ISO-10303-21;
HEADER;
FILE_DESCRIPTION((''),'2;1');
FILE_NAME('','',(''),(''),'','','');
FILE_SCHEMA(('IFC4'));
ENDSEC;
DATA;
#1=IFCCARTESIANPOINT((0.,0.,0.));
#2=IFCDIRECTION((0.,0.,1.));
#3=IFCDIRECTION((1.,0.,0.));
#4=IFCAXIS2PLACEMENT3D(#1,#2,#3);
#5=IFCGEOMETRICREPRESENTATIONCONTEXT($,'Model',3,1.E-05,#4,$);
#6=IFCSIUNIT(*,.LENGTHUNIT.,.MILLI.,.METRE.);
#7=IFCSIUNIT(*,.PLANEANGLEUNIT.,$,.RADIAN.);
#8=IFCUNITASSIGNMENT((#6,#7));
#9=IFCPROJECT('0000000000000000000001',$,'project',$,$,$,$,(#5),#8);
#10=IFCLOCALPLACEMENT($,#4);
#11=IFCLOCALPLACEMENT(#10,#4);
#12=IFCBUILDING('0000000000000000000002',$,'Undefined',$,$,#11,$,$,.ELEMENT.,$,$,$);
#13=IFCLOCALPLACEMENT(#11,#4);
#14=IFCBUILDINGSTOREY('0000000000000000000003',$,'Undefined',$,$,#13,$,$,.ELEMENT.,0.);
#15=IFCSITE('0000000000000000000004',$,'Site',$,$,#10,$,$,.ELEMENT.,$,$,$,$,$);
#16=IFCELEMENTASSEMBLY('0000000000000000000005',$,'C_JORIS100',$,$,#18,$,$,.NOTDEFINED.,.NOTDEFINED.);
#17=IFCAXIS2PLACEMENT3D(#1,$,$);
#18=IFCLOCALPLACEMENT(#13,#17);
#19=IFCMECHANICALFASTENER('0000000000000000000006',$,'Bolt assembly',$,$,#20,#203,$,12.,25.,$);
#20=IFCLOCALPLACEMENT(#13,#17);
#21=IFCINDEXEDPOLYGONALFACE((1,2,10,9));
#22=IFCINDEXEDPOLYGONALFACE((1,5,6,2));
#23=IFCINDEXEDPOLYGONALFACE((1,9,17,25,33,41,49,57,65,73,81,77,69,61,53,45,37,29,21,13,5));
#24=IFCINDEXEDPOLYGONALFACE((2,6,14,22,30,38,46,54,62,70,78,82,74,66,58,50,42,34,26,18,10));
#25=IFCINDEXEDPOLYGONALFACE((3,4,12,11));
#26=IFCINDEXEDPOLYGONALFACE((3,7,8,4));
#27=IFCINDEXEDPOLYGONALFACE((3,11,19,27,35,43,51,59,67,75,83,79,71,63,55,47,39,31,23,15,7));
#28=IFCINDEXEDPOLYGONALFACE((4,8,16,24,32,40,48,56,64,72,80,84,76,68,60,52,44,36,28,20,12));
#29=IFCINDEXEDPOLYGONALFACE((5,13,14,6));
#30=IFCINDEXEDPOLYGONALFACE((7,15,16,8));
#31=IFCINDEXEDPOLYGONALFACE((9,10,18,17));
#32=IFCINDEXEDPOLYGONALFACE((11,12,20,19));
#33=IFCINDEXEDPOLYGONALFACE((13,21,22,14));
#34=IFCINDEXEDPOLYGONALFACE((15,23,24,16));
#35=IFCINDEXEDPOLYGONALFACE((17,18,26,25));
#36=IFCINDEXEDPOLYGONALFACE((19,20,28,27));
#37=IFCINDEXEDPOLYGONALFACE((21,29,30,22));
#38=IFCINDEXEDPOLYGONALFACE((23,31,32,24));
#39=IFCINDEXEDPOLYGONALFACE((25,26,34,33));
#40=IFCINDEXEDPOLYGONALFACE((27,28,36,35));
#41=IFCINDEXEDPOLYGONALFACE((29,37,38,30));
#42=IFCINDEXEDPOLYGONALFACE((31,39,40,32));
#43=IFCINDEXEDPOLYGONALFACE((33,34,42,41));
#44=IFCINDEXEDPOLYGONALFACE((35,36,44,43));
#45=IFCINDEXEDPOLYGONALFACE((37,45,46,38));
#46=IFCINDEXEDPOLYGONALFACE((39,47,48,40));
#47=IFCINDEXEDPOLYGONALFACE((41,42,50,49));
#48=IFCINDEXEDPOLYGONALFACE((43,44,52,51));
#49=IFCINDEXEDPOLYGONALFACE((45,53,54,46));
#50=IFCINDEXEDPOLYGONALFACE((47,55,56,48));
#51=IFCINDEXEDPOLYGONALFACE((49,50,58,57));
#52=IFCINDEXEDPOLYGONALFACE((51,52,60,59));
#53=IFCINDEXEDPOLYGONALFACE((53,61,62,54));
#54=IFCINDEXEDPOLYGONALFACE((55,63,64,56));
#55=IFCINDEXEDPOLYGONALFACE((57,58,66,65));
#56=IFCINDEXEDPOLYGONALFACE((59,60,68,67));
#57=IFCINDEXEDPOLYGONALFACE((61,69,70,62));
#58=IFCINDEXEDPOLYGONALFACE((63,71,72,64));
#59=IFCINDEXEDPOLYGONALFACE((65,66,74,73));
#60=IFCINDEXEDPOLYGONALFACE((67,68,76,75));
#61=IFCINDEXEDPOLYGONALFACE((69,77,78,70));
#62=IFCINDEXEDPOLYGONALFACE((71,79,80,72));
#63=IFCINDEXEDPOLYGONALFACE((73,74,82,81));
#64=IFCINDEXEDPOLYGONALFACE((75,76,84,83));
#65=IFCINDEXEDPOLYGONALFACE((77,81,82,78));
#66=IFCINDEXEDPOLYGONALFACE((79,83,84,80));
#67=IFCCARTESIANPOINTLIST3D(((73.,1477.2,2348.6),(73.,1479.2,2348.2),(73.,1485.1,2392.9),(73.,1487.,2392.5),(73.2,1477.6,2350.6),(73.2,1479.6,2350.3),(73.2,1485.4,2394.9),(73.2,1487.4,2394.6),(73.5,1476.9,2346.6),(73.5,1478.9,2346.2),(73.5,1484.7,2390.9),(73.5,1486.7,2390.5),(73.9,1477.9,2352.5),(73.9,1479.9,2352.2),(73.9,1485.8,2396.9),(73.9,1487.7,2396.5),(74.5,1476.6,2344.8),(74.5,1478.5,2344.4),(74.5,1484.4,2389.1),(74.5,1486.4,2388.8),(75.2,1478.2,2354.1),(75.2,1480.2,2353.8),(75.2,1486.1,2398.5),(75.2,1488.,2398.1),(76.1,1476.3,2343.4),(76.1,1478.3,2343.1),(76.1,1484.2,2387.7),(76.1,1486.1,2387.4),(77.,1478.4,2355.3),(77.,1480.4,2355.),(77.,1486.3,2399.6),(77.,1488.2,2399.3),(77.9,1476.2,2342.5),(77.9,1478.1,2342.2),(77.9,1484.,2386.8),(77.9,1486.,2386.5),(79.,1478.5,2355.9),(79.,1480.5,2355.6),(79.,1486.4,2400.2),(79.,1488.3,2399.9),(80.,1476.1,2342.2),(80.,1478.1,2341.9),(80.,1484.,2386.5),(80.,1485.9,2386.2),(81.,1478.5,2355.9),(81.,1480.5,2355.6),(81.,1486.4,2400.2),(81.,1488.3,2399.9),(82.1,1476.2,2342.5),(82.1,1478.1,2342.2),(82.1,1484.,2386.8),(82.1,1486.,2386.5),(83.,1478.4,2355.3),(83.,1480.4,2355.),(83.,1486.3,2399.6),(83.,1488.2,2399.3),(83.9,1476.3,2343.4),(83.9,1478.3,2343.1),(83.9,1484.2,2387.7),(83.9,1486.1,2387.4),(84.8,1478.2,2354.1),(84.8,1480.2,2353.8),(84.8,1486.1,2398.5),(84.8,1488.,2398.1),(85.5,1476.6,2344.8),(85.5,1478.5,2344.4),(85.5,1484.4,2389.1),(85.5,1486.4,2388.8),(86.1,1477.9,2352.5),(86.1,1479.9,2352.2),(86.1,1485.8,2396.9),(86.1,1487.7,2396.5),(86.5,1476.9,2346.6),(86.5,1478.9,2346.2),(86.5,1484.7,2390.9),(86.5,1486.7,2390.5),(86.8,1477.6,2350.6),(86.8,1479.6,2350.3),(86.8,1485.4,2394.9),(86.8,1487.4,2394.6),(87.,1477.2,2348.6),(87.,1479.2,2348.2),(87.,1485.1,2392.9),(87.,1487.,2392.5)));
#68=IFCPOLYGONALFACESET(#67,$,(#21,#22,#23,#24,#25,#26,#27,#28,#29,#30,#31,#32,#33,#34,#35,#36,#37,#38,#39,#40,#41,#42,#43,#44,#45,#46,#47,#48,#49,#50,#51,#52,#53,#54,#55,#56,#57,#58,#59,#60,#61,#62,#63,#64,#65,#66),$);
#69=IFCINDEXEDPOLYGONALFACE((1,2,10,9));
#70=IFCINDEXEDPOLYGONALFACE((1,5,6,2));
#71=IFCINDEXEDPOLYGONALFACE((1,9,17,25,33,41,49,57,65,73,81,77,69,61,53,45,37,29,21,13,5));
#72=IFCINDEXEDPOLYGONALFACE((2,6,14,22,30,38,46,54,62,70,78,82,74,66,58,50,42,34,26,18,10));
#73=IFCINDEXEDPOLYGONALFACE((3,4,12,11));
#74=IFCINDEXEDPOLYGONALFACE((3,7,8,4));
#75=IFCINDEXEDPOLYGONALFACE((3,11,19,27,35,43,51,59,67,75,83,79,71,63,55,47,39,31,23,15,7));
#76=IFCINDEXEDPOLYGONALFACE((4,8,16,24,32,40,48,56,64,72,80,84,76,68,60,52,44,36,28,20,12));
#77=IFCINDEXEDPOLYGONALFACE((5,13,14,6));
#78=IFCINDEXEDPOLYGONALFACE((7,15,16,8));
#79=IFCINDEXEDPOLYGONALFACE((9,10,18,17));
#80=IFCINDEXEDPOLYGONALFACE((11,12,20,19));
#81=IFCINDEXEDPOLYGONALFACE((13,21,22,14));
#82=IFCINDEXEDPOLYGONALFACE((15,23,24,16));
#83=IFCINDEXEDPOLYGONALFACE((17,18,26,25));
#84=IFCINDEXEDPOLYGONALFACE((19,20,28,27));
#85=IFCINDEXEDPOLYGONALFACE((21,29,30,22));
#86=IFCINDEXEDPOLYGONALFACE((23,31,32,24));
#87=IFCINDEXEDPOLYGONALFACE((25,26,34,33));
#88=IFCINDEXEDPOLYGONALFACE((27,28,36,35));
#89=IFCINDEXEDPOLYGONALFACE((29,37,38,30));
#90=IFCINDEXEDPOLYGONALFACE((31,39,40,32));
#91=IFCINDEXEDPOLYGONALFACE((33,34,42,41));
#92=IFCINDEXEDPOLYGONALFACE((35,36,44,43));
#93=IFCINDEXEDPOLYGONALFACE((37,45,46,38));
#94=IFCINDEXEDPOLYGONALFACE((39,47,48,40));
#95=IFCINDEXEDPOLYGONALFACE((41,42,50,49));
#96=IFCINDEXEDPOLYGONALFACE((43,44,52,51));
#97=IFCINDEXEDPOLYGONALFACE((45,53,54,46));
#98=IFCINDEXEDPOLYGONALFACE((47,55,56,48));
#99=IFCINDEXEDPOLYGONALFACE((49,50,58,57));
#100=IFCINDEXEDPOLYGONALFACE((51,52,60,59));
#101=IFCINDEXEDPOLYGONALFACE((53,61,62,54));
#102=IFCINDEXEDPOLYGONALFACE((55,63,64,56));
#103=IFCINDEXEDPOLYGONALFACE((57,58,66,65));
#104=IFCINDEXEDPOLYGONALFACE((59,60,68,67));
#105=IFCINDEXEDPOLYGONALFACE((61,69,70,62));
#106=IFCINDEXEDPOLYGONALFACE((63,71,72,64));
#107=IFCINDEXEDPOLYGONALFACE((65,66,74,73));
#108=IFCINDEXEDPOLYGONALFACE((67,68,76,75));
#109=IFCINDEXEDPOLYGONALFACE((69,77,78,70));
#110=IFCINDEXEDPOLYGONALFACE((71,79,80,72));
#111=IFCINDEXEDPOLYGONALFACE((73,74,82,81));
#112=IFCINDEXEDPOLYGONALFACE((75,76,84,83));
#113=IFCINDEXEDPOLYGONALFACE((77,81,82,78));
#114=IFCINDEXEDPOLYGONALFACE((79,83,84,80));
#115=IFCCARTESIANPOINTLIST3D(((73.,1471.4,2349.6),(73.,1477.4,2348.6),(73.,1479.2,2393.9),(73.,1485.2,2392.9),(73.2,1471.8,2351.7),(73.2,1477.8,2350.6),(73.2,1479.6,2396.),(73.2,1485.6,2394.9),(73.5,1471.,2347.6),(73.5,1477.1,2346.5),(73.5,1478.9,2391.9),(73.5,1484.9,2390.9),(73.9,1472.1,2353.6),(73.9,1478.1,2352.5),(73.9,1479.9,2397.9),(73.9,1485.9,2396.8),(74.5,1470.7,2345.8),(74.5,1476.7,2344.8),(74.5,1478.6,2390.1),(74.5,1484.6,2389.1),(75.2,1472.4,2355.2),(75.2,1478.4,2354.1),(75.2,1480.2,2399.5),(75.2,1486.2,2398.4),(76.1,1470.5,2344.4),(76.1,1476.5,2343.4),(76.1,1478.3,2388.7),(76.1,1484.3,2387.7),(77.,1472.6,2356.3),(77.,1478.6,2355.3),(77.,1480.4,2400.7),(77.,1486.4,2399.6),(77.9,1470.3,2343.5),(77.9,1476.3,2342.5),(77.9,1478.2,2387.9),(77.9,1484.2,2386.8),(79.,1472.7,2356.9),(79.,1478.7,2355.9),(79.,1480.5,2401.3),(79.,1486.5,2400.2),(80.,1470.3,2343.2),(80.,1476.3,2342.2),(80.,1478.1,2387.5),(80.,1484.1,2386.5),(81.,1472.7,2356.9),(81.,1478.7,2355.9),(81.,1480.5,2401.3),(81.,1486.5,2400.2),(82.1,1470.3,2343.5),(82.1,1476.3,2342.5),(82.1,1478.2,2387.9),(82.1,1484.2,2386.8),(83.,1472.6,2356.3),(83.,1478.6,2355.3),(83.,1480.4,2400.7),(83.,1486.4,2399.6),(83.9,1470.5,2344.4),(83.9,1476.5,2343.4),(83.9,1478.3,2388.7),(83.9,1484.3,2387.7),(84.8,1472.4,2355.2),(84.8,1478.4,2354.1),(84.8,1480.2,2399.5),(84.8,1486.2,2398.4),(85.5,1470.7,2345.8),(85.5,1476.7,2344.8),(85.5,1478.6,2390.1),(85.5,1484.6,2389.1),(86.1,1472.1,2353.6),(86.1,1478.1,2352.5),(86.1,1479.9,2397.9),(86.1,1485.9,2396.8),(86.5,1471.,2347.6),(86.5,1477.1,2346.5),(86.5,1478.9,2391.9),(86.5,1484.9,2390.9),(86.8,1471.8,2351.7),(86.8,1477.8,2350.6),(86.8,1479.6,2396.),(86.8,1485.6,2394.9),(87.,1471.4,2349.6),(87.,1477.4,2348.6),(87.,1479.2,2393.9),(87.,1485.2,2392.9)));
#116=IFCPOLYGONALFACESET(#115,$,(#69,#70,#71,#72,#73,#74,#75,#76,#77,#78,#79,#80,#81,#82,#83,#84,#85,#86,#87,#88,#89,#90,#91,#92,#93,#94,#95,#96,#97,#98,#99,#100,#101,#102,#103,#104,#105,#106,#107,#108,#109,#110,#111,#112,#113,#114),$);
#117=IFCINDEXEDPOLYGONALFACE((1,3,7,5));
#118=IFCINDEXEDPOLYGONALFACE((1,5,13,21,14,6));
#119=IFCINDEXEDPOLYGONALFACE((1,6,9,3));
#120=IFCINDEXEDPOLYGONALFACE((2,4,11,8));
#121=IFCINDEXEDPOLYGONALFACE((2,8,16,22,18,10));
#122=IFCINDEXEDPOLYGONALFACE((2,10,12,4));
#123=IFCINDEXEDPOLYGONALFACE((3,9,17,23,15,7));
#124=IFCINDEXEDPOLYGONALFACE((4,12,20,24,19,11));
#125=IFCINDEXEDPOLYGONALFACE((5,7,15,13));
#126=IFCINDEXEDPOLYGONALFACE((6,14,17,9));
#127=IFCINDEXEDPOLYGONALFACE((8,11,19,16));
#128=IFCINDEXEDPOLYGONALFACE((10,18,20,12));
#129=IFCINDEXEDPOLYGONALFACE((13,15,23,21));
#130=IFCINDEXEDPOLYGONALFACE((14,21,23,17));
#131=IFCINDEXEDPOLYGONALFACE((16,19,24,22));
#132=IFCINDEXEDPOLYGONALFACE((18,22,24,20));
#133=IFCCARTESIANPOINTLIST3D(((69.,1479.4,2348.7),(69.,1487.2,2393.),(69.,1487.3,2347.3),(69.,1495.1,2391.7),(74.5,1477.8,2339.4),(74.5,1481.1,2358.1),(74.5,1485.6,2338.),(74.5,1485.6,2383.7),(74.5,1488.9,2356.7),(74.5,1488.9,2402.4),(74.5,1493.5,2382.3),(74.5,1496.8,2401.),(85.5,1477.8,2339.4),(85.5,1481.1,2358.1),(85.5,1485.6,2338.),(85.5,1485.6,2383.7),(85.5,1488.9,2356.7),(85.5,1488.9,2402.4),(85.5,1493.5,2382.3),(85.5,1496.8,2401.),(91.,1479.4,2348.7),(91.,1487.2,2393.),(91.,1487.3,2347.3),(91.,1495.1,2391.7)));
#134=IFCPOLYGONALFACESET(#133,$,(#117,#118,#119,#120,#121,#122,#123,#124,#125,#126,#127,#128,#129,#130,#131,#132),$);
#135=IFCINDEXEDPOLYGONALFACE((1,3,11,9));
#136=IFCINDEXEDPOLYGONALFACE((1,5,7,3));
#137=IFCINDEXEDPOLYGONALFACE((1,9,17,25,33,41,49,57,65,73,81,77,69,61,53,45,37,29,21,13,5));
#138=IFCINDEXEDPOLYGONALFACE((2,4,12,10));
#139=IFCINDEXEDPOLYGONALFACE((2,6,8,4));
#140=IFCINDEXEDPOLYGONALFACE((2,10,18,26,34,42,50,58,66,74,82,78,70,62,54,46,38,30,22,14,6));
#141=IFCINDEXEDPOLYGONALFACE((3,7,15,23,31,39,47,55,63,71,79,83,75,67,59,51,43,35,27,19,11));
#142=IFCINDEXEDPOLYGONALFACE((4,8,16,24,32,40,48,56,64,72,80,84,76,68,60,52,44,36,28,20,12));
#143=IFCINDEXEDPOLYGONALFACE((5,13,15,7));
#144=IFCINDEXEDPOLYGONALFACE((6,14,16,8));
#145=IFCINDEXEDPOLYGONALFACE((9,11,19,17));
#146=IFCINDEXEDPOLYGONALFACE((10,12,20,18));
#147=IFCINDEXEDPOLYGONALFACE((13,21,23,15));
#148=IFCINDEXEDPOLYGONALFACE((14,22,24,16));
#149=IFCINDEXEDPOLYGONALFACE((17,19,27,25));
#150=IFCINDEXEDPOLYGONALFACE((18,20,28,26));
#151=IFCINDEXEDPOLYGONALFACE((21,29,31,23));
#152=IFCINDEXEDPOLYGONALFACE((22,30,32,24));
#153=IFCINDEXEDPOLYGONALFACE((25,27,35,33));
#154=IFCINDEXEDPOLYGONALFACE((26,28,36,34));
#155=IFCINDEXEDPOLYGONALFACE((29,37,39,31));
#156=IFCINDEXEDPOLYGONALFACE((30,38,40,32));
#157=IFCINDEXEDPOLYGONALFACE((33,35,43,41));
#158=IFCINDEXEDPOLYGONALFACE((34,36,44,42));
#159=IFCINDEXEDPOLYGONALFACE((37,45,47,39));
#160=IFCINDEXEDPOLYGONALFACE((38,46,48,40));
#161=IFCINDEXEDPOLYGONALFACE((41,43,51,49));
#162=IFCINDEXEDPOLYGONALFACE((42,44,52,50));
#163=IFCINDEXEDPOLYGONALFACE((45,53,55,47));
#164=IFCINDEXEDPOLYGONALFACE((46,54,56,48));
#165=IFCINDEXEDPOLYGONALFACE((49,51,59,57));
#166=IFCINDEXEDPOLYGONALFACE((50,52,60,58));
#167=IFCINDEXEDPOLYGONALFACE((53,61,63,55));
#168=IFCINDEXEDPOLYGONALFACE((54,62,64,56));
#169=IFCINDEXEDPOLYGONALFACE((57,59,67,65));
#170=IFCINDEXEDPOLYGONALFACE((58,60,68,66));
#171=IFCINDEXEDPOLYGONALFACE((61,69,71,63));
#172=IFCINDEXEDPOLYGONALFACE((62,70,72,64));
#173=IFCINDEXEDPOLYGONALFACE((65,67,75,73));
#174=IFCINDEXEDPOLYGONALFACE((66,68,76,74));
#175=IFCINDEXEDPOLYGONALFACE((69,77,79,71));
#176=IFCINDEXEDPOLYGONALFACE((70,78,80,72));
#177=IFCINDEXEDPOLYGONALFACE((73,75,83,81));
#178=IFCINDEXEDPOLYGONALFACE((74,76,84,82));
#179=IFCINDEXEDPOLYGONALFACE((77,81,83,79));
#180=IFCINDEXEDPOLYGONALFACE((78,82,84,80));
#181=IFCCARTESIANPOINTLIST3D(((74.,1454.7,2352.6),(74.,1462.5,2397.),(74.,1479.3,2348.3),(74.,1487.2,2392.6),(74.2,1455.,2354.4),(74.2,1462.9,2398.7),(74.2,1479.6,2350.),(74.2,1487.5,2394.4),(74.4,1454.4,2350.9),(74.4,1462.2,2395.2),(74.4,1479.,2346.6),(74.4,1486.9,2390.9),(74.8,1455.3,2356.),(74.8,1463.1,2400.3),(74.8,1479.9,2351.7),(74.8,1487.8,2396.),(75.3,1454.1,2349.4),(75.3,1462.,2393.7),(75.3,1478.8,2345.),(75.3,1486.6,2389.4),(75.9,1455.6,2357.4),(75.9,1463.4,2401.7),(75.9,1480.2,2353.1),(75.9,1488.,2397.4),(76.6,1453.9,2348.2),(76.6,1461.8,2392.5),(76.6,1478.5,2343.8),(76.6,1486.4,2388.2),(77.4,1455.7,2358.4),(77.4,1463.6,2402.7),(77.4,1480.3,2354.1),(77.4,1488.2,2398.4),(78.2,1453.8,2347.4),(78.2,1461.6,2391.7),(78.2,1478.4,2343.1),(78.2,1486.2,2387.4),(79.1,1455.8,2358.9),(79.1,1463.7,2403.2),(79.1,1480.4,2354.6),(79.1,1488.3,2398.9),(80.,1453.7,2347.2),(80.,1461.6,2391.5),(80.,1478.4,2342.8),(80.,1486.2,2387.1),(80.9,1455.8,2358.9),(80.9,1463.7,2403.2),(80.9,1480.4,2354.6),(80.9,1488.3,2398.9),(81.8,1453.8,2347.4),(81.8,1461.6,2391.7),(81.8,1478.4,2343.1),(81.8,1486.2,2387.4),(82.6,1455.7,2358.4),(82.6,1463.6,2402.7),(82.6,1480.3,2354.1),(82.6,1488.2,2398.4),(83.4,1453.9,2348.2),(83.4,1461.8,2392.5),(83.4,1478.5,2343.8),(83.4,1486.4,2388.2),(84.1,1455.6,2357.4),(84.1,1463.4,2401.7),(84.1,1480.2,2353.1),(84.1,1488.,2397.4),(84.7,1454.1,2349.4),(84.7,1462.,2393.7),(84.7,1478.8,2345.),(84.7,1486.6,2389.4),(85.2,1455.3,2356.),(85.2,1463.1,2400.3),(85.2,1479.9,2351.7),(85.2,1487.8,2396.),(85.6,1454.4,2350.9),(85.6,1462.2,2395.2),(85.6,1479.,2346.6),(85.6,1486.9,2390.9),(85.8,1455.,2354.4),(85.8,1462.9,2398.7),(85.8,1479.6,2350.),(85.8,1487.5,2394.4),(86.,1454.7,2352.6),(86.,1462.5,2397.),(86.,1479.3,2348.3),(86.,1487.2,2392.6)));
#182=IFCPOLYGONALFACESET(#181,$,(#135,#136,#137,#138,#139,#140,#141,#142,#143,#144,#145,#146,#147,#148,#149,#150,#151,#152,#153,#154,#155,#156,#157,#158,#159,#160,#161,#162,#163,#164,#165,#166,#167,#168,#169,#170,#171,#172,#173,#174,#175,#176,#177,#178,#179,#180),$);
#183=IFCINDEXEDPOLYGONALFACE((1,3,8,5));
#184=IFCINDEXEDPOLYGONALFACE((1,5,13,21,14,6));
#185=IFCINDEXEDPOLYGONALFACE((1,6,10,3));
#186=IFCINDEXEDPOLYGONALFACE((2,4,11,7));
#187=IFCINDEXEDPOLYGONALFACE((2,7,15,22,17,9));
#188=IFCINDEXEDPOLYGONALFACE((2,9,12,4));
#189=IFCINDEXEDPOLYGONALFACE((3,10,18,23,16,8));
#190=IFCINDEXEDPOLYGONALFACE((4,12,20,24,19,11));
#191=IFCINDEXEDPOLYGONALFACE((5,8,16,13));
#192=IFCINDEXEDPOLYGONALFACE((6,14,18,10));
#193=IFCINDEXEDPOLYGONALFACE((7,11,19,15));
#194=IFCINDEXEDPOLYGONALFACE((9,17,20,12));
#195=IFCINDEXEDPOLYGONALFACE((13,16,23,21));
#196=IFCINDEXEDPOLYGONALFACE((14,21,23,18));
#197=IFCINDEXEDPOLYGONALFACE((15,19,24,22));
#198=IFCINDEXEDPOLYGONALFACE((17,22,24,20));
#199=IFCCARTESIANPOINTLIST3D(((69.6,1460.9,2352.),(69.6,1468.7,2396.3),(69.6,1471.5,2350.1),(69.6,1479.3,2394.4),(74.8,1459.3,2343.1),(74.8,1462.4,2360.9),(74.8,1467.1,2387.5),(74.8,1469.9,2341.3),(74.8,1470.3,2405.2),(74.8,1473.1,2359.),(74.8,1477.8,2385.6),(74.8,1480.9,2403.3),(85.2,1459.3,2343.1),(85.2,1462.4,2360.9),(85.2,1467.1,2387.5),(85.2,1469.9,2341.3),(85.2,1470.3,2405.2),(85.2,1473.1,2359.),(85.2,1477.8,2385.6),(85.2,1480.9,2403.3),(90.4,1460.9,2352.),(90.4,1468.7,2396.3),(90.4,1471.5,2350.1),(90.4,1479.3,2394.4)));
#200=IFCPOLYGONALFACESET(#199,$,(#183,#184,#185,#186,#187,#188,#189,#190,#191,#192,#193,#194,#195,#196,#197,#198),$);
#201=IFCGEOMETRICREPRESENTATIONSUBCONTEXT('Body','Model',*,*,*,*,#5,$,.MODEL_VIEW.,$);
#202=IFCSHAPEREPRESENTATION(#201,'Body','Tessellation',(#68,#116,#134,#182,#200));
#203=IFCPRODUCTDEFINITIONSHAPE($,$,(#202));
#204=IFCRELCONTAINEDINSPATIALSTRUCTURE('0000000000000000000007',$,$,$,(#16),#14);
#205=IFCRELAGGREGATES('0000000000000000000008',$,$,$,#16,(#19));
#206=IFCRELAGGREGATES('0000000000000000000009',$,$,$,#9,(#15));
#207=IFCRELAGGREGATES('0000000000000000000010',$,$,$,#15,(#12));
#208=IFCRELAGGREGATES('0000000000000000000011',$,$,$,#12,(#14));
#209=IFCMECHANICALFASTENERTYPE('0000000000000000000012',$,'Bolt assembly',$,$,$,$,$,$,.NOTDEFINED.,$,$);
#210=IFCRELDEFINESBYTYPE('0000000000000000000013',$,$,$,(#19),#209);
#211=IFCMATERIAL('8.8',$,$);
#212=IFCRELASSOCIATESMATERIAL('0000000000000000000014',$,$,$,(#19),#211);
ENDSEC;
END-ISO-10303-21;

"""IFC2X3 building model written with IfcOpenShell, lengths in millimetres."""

from ifc_helpers import new_model, si_unit, frame, origin_with_axes, origin_2d_with_axis, place, context, subcontext, project, spatial, polyline, circle, outline, extrude, source, transform, mapped, material, type_object, element, aggregate, save


model = new_model("IFC2X3")

# Units and contexts
model_context = context("Model", 3, precision=1e-05, world=origin_with_axes())
body_context = subcontext(model_context, "Body", "Model", "MODEL_VIEW")
ifc_project = project(units=[si_unit("LENGTHUNIT", "METRE", prefix="MILLI"), si_unit("PLANEANGLEUNIT", "RADIAN")], contexts=[model_context])

# Site, building, storey
site_placement = place(None, origin_with_axes())
site = spatial("IfcSite", under=ifc_project, at=site_placement, Name="Site", CompositionType="ELEMENT")
building_placement = place(site_placement, origin_with_axes())
building = spatial("IfcBuilding", under=site, at=building_placement, Name="Undefined", CompositionType="ELEMENT")
storey_placement = place(building_placement, origin_with_axes())
storey = spatial("IfcBuildingStorey", under=building, at=storey_placement, Name="Undefined", CompositionType="ELEMENT", Elevation=0.0)

# Element assembly
assembly_1_placement = place(storey_placement, origin_with_axes())
assembly_1 = element("IfcElementAssembly", 1, at=assembly_1_placement, inside=storey, Name="C_JORIS100", AssemblyPlace="NOTDEFINED", PredefinedType="NOTDEFINED")

# Shared definitions
ifc_material_1 = material(Name="8.8")
mechanical_fastener_type = type_object("IfcMechanicalFastenerType", Name="Bolt assembly")

# Mechanical fastener
shared_shape_1 = source(origin_with_axes(), body_context, "Body", "SweptSolid", [
    extrude(circle(Radius=7.0, at=origin_2d_with_axis()), frame((0.0, -4.9, 0.0), z_axis=(0.0, 1.0, 0.0), x_axis=(1.0, 0.0, 0.0)), (0.0, 0.0, 1.0), 2.0),
    extrude(circle(Radius=7.0, at=origin_2d_with_axis()), frame((0.0, -3.1, 0.0), z_axis=(0.0, 1.0, 0.0), x_axis=(1.0, 0.0, 0.0)), (0.0, 0.0, 1.0), 6.1),
    extrude(outline(polyline([(9.5, -5.5), (9.5, 5.5), (0.0, 11.0), (-9.5, 5.5), (-9.5, -5.5), (0.0, -11.0), (9.5, -5.5)])), frame((0.0, -13.0, 0.0), z_axis=(0.0, 1.0, 0.0), x_axis=(1.0, 0.0, 0.0)), (0.0, 0.0, 1.0), 8.0),
    extrude(circle(Radius=6.0, at=origin_2d_with_axis()), frame((0.0, -5.0, 0.0), z_axis=(0.0, 1.0, 0.0), x_axis=(1.0, 0.0, 0.0)), (0.0, 0.0, 1.0), 25.0),
    extrude(outline(polyline([(9.0, -5.2), (9.0, 5.2), (0.0, 10.4), (-9.0, 5.2), (-9.0, -5.2), (0.0, -10.4), (9.0, -5.2)])), frame((0.0, 3.0, 0.0), z_axis=(0.0, 1.0, 0.0), x_axis=(1.0, 0.0, 0.0)), (0.0, 0.0, 1.0), 10.8),
])
mechanical_fastener_1_placement = place(assembly_1_placement, frame((80.0, 1482.3, 2393.9), z_axis=(-1.0, 0.0, 0.0), x_axis=(0.0, -0.174019, -0.984742)))
mechanical_fastener_1 = element("IfcMechanicalFastener", 2, at=mechanical_fastener_1_placement, type_object=mechanical_fastener_type, material=ifc_material_1, Name="Bolt assembly", NominalDiameter=12.0, NominalLength=25.0, context=body_context, shape_type="MappedRepresentation", body=[
    mapped(shared_shape_1, transform((0.0, 0.0, 0.0))),
    mapped(shared_shape_1, transform((45.0, 0.0, 0.0))),
])
aggregate(assembly_1, [mechanical_fastener_1])

save(model, "model.ifc")
